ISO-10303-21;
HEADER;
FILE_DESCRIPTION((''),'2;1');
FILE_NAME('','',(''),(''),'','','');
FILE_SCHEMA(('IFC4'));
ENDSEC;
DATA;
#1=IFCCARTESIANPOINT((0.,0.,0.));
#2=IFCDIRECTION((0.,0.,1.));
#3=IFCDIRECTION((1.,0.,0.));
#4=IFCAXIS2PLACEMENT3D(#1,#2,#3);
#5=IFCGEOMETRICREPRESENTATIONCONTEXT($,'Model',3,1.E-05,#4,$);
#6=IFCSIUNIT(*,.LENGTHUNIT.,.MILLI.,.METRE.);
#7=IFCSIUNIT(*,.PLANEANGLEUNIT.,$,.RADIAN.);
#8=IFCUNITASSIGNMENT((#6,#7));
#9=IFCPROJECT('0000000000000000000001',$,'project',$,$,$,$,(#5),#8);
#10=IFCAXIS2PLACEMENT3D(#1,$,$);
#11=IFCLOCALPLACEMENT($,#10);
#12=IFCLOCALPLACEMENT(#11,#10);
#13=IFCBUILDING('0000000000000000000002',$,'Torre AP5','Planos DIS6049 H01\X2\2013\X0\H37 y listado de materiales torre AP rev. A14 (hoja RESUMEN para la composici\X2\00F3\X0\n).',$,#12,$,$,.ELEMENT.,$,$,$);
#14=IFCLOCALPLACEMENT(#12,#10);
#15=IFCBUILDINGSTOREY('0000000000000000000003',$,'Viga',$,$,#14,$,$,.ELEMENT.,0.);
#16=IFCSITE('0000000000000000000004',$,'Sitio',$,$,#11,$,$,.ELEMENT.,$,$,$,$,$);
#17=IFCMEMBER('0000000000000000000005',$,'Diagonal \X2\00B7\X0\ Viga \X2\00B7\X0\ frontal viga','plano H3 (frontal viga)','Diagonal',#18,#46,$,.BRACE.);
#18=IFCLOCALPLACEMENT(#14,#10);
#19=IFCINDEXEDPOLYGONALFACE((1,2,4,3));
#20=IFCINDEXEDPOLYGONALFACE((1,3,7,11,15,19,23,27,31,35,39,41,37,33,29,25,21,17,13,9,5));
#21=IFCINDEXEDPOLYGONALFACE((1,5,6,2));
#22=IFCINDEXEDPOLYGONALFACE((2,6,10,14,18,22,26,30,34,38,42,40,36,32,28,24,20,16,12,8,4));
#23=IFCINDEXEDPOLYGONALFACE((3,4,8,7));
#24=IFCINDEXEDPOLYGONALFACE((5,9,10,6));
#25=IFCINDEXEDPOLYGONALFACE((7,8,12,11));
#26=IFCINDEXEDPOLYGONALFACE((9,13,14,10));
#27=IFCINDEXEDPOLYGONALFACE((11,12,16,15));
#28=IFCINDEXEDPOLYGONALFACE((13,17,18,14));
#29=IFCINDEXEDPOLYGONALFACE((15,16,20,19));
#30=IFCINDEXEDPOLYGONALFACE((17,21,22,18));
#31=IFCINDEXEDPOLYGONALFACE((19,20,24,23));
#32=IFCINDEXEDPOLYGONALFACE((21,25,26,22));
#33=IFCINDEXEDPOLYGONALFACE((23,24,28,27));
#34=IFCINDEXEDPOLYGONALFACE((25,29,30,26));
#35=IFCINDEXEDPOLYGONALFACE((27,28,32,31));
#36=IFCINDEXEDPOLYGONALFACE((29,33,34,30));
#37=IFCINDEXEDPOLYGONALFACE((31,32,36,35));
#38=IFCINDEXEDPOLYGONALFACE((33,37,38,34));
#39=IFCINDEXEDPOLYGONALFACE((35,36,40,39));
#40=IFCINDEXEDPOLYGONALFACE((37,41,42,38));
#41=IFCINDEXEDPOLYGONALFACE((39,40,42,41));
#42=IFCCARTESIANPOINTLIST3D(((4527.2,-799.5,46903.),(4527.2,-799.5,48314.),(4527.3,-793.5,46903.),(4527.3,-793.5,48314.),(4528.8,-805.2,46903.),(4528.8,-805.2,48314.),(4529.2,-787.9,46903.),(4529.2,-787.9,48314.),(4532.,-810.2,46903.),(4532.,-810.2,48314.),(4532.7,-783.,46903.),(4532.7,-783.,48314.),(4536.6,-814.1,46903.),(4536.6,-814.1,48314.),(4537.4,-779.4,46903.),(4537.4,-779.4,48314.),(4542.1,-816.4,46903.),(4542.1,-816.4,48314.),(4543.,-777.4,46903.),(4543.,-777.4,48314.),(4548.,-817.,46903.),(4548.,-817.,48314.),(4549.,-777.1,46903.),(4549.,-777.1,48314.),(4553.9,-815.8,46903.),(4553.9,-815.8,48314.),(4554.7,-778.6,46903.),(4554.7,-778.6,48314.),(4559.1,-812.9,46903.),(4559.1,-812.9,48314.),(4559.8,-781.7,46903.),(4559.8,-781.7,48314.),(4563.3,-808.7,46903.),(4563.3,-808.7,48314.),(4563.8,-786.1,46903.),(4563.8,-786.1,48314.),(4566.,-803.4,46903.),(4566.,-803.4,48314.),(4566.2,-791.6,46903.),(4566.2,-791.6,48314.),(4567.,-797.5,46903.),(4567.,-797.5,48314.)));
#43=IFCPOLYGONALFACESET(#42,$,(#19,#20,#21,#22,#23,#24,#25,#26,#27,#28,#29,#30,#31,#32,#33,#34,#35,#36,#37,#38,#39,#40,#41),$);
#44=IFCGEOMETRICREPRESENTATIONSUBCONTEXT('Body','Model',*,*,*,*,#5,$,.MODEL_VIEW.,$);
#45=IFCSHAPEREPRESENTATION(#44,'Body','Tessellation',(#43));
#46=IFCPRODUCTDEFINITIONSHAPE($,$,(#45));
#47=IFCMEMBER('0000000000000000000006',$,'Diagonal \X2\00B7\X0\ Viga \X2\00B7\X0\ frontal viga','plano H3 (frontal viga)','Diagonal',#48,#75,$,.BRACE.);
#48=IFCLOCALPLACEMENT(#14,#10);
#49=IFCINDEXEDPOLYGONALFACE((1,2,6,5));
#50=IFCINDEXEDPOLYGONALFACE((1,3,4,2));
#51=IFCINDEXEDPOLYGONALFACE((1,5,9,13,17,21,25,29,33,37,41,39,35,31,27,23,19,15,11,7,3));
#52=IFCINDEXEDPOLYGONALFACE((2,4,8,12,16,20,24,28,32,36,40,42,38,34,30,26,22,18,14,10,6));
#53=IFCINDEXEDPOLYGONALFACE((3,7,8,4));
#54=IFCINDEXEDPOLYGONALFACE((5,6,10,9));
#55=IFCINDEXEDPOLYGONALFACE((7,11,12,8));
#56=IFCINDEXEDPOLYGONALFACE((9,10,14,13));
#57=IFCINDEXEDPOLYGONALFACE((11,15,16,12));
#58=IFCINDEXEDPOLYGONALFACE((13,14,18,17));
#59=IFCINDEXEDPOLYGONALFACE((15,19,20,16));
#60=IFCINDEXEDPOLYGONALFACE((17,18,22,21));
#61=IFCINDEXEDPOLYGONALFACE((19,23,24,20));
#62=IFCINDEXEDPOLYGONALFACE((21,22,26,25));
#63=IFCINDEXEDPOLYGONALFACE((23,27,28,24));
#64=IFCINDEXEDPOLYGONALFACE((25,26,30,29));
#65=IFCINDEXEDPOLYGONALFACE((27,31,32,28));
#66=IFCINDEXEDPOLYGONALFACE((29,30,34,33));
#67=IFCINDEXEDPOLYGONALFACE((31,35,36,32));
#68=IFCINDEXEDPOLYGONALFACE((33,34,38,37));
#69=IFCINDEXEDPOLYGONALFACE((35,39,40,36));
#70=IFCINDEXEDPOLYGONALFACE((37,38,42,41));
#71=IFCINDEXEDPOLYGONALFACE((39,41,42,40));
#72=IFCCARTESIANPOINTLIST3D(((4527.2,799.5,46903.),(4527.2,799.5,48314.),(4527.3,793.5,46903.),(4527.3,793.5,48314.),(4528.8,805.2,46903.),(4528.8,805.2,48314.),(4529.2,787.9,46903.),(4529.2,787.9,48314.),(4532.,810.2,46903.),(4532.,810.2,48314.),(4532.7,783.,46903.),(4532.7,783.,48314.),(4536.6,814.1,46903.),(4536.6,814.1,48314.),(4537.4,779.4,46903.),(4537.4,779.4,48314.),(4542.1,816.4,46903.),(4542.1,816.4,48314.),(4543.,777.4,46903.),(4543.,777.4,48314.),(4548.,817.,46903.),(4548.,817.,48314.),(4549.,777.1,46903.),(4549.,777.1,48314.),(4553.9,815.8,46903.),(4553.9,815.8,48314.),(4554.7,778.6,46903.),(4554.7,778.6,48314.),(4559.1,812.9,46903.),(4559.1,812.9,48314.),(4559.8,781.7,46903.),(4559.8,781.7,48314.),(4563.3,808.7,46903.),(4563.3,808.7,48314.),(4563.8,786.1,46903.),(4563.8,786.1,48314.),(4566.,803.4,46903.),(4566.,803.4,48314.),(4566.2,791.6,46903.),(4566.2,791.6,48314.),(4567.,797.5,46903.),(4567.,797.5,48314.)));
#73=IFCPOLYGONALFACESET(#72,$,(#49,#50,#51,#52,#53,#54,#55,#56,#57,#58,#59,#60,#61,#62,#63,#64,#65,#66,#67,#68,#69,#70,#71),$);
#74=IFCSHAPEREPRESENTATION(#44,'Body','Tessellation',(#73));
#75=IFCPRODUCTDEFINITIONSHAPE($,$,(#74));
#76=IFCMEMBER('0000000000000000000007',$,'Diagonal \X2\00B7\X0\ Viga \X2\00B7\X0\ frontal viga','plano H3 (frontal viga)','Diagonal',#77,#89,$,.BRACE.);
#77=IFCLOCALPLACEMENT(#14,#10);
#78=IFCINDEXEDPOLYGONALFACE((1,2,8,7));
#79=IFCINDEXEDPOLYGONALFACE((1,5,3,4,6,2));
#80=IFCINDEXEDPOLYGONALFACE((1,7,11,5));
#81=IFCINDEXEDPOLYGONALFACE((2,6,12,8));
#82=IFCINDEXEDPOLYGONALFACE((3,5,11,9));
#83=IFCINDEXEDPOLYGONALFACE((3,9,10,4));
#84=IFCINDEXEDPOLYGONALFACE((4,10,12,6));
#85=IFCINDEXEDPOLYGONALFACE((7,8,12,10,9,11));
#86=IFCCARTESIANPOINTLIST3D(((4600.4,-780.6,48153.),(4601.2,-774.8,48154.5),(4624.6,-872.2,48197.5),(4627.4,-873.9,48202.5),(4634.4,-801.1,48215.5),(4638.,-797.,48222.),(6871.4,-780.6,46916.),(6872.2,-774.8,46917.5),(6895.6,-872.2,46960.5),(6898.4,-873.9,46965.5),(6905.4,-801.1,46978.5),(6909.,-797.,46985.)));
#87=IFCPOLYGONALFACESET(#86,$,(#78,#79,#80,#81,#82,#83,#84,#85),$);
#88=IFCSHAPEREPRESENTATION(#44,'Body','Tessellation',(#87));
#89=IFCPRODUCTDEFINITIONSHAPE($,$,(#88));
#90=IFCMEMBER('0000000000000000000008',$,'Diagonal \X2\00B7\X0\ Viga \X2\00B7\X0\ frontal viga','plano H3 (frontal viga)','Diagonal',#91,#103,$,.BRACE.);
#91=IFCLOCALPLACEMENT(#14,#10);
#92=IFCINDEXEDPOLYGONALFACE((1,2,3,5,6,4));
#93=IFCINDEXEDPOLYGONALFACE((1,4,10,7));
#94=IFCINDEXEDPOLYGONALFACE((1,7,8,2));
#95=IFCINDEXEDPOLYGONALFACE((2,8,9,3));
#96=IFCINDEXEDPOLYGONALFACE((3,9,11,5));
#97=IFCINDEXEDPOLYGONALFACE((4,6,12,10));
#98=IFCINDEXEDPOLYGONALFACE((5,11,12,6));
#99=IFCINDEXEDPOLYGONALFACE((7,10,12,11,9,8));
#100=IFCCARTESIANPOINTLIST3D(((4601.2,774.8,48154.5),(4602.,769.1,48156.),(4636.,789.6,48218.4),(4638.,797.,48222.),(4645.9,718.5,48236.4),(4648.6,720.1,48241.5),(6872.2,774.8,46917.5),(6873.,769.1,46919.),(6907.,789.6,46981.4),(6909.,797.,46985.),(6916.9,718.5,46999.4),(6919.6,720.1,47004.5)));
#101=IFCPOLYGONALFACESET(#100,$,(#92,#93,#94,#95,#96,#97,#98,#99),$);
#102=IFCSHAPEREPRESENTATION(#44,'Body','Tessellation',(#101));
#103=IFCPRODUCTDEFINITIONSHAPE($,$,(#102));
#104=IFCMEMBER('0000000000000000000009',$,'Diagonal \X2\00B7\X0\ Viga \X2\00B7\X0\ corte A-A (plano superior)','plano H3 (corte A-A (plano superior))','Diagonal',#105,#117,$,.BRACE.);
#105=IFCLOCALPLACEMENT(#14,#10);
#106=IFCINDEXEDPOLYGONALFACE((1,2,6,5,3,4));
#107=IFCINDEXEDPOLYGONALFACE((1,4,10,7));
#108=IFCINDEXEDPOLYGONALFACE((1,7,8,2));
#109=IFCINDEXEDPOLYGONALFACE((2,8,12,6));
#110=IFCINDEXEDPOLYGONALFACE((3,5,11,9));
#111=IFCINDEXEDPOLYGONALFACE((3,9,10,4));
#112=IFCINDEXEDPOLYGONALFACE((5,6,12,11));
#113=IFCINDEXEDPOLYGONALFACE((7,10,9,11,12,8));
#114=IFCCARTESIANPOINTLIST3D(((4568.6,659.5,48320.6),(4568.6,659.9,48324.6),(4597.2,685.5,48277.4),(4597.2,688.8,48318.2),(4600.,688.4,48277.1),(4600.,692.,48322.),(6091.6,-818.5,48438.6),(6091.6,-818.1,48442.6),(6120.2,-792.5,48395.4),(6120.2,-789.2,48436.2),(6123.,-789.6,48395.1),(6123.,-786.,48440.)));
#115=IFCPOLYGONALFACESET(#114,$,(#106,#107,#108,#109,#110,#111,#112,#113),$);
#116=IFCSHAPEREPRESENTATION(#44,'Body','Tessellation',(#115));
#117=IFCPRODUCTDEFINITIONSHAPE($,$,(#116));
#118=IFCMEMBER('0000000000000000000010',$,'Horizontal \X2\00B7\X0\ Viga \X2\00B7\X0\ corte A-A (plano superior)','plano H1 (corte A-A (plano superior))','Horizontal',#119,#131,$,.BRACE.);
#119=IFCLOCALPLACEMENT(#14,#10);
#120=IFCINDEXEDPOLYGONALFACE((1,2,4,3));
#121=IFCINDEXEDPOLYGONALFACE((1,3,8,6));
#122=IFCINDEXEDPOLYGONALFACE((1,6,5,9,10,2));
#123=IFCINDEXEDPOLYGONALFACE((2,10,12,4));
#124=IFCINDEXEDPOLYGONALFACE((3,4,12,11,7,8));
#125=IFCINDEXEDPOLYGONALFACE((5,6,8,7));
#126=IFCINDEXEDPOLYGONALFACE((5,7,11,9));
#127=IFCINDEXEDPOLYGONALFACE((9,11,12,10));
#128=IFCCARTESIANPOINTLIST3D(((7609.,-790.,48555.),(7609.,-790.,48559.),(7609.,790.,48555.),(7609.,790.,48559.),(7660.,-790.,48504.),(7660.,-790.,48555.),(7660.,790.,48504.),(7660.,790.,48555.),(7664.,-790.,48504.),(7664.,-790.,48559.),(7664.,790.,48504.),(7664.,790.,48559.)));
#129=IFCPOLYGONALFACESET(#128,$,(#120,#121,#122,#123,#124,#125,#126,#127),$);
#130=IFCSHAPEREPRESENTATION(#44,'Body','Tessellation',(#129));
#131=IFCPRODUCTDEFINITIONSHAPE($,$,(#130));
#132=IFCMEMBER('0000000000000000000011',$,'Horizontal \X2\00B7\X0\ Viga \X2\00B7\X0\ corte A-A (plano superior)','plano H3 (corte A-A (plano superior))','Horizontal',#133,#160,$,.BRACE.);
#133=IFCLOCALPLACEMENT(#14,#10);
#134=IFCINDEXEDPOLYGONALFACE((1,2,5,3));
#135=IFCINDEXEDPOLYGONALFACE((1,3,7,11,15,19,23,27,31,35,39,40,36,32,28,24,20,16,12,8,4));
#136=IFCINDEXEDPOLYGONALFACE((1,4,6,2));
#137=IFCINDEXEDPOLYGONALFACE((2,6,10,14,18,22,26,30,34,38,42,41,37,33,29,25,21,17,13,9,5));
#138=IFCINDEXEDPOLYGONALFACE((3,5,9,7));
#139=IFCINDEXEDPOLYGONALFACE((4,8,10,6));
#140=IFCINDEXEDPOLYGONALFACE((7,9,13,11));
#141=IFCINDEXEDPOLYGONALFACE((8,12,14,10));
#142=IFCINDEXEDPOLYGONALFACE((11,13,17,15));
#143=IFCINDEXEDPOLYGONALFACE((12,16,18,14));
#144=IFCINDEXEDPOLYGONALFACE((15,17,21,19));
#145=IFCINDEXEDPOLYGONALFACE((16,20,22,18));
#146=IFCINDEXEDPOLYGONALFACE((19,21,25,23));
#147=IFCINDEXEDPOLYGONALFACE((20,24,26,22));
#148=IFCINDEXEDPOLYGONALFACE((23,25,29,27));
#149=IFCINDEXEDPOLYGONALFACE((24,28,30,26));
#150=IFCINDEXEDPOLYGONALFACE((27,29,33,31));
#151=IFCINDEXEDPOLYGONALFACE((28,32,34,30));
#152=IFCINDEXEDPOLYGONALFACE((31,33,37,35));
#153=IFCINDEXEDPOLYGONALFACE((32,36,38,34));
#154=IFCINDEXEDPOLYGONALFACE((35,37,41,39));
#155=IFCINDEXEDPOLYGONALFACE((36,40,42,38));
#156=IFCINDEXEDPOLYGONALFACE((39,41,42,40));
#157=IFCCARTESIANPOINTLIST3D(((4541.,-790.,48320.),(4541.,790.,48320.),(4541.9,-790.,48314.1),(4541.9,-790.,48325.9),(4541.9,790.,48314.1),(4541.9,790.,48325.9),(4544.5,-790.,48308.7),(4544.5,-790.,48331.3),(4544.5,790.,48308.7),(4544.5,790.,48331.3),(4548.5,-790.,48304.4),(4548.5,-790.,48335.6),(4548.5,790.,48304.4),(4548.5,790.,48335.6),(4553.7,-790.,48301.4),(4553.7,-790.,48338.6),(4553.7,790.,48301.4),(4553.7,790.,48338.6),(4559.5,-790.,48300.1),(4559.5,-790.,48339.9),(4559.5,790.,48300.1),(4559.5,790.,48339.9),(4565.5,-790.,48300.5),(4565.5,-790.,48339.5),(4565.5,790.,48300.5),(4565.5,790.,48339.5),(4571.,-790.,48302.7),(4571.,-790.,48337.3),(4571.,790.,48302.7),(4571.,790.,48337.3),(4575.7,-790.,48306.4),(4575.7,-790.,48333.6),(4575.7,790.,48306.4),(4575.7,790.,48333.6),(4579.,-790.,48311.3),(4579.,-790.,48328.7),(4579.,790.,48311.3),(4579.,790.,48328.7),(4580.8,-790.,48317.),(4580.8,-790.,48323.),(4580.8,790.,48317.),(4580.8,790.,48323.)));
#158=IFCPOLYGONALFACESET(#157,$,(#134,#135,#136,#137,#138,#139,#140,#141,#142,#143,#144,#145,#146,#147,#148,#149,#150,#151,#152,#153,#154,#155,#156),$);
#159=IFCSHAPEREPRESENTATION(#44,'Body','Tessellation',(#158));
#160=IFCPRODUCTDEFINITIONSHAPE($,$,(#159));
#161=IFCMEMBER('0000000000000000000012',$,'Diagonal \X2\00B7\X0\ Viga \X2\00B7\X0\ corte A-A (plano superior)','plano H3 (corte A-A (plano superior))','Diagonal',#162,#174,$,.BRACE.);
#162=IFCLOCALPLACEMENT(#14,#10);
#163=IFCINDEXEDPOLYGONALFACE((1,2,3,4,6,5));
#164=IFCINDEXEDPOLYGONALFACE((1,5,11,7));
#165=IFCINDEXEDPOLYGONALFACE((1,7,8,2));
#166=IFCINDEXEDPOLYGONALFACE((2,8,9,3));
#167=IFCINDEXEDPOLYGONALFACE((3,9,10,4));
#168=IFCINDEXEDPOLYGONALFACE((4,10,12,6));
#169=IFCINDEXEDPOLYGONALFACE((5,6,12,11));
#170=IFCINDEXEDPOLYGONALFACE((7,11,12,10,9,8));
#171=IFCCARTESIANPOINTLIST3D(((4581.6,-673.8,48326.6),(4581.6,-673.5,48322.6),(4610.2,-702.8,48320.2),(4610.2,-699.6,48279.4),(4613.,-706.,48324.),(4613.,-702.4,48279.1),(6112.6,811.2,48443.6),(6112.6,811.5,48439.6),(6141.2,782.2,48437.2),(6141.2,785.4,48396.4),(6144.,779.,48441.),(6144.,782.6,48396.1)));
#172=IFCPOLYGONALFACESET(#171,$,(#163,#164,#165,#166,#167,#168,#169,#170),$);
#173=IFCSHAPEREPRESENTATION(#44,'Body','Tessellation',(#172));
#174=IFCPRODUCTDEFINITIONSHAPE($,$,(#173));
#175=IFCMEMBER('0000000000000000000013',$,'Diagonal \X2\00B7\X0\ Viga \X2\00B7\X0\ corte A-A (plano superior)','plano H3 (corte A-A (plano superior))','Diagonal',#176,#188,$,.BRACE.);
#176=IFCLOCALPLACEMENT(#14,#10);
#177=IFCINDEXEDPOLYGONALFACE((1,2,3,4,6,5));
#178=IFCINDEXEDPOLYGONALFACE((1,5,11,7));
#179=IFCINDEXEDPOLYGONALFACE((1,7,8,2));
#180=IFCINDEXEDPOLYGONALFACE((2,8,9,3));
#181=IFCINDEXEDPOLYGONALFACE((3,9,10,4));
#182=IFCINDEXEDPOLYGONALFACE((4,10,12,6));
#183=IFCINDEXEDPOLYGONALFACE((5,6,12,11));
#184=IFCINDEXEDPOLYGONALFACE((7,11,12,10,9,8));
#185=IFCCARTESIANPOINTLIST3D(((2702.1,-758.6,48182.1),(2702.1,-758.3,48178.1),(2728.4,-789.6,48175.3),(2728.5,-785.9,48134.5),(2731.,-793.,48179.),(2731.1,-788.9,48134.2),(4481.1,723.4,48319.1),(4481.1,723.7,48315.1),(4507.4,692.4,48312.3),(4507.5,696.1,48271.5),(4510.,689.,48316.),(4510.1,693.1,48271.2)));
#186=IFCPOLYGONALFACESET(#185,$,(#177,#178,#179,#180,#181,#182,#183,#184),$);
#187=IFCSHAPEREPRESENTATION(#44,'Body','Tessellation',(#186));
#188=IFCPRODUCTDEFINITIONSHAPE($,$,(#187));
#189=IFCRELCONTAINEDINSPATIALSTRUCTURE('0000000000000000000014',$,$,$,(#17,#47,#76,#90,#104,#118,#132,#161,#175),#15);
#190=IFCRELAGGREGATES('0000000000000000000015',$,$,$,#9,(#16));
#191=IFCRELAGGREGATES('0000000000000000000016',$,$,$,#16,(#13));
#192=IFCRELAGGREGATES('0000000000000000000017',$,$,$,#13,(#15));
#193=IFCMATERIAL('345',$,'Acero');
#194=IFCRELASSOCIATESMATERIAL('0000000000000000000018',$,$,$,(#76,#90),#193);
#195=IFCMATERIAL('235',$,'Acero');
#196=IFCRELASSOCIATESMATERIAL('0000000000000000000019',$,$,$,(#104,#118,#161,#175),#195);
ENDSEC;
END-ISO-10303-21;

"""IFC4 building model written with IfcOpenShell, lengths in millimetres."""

from ifc_helpers import new_model, si_unit, frame, frame_2d, origin, origin_with_axes, place, context, subcontext, project, spatial, circle, l_section, extrude, material, element, save


model = new_model("IFC4")

# Units and contexts
model_context = context("Model", 3, precision=1e-05, world=origin_with_axes())
body_context = subcontext(model_context, "Body", "Model", "MODEL_VIEW")
ifc_project = project(units=[si_unit("LENGTHUNIT", "METRE", prefix="MILLI"), si_unit("PLANEANGLEUNIT", "RADIAN")], contexts=[model_context])

# Site, building, storey
site_placement = place(None, origin())
site = spatial("IfcSite", under=ifc_project, at=site_placement, Name="Sitio", CompositionType="ELEMENT")
building_placement = place(site_placement, origin())
building = spatial("IfcBuilding", under=site, at=building_placement, Name="Torre AP5", Description="Planos DIS6049 H01–H37 y listado de materiales torre AP rev. A14 (hoja RESUMEN para la composición).", CompositionType="ELEMENT")
storey_placement = place(building_placement, origin())
storey = spatial("IfcBuildingStorey", under=building, at=storey_placement, Name="Viga", CompositionType="ELEMENT", Elevation=0.0)

# Members
ifc_material_1 = material(Name="235", Category="Acero")
ifc_material_2 = material(Name="345", Category="Acero")
for number, where, z_axis, x_axis, name in (
    (1, (4547.0, -797.0, 46903.0), (0.0, 0.0, 1.0), (-0.984984, 0.172648, 0.0), "Diagonal · Viga · frontal viga"),
    (2, (4547.0, 797.0, 46903.0), (0.0, 0.0, 1.0), (-0.984984, -0.172648, 0.0), "Diagonal · Viga · frontal viga"),
):
    element("IfcMember", number, at=place(storey_placement, frame(where, z_axis=z_axis, x_axis=x_axis)), inside=storey, Name=name, Description="plano H3 (frontal viga)", ObjectType="Diagonal", PredefinedType="BRACE", context=body_context, shape_type="SweptSolid", body=[
        extrude(circle(Radius=20.0), None, (0.0, 0.0, 1.0), 1411.0),
    ])
for number, where, z_axis, x_axis, name in (
    (3, (6909.0, -797.0, 46985.0), (-0.878176, 0.0, 0.478337), (-0.459582, 0.277277, -0.843743), "Diagonal · Viga · frontal viga"),
    (4, (6909.0, 797.0, 46985.0), (-0.878176, 0.0, 0.478337), (-0.459582, -0.277277, -0.843743), "Diagonal · Viga · frontal viga"),
):
    element("IfcMember", number, at=place(storey_placement, frame(where, z_axis=z_axis, x_axis=x_axis)), inside=storey, material=ifc_material_2, Name=name, Description="plano H3 (frontal viga)", ObjectType="Diagonal", PredefinedType="BRACE", context=body_context, shape_type="SweptSolid", body=[
        extrude(l_section(Depth=80.0, Width=80.0, Thickness=6.0, at=frame_2d((40.0, 40.0))), None, (0.0, 0.0, 1.0), 2586.0),
    ])
member_1_placement = place(storey_placement, frame((4600.0, 692.0, 48322.0), z_axis=(0.716522, -0.695351, 0.055515), x_axis=(-0.697564, -0.714169, 0.05803)))
element("IfcMember", 5, at=member_1_placement, inside=storey, material=ifc_material_1, Name="Diagonal · Viga · corte A-A (plano superior)", Description="plano H3 (corte A-A (plano superior))", ObjectType="Diagonal", PredefinedType="BRACE", context=body_context, shape_type="SweptSolid", body=[
    extrude(l_section(Depth=45.0, Width=45.0, Thickness=4.0, at=frame_2d((22.5, 22.5))), None, (0.0, 0.0, 1.0), 2125.5),
])
member_2_placement = place(storey_placement, frame((7664.0, 790.0, 48559.0), z_axis=(0.0, -1.0, 0.0), x_axis=(-1.0, 0.0, 0.0)))
element("IfcMember", 6, at=member_2_placement, inside=storey, material=ifc_material_1, Name="Horizontal · Viga · corte A-A (plano superior)", Description="plano H1 (corte A-A (plano superior))", ObjectType="Horizontal", PredefinedType="BRACE", context=body_context, shape_type="SweptSolid", body=[
    extrude(l_section(Depth=55.0, Width=55.0, Thickness=4.0, at=frame_2d((27.5, 27.5))), None, (0.0, 0.0, 1.0), 1580.0),
])
member_3_placement = place(storey_placement, frame((4561.0, 790.0, 48320.0), z_axis=(0.0, -1.0, 0.0), x_axis=(-1.0, 0.0, 0.0)))
element("IfcMember", 7, at=member_3_placement, inside=storey, Name="Horizontal · Viga · corte A-A (plano superior)", Description="plano H3 (corte A-A (plano superior))", ObjectType="Horizontal", PredefinedType="BRACE", context=body_context, shape_type="SweptSolid", body=[
    extrude(circle(Radius=20.0), None, (0.0, 0.0, 1.0), 1580.0),
])
member_4_placement = place(storey_placement, frame((6144.0, 779.0, 48441.0), z_axis=(-0.716731, -0.695196, -0.054773), x_axis=(-0.69735, 0.714456, 0.057063)))
element("IfcMember", 8, at=member_4_placement, inside=storey, material=ifc_material_1, Name="Diagonal · Viga · corte A-A (plano superior)", Description="plano H3 (corte A-A (plano superior))", ObjectType="Diagonal", PredefinedType="BRACE", context=body_context, shape_type="SweptSolid", body=[
    extrude(l_section(Depth=45.0, Width=45.0, Thickness=4.0, at=frame_2d((22.5, 22.5))), None, (0.0, 0.0, 1.0), 2136.1),
])
member_5_placement = place(storey_placement, frame((4510.0, 689.0, 48316.0), z_axis=(-0.766986, -0.638939, -0.059065), x_axis=(-0.641662, 0.763915, 0.068584)))
element("IfcMember", 9, at=member_5_placement, inside=storey, material=ifc_material_1, Name="Diagonal · Viga · corte A-A (plano superior)", Description="plano H3 (corte A-A (plano superior))", ObjectType="Diagonal", PredefinedType="BRACE", context=body_context, shape_type="SweptSolid", body=[
    extrude(l_section(Depth=45.0, Width=45.0, Thickness=4.0, at=frame_2d((22.5, 22.5))), None, (0.0, 0.0, 1.0), 2319.5),
])

save(model, "model.ifc")
